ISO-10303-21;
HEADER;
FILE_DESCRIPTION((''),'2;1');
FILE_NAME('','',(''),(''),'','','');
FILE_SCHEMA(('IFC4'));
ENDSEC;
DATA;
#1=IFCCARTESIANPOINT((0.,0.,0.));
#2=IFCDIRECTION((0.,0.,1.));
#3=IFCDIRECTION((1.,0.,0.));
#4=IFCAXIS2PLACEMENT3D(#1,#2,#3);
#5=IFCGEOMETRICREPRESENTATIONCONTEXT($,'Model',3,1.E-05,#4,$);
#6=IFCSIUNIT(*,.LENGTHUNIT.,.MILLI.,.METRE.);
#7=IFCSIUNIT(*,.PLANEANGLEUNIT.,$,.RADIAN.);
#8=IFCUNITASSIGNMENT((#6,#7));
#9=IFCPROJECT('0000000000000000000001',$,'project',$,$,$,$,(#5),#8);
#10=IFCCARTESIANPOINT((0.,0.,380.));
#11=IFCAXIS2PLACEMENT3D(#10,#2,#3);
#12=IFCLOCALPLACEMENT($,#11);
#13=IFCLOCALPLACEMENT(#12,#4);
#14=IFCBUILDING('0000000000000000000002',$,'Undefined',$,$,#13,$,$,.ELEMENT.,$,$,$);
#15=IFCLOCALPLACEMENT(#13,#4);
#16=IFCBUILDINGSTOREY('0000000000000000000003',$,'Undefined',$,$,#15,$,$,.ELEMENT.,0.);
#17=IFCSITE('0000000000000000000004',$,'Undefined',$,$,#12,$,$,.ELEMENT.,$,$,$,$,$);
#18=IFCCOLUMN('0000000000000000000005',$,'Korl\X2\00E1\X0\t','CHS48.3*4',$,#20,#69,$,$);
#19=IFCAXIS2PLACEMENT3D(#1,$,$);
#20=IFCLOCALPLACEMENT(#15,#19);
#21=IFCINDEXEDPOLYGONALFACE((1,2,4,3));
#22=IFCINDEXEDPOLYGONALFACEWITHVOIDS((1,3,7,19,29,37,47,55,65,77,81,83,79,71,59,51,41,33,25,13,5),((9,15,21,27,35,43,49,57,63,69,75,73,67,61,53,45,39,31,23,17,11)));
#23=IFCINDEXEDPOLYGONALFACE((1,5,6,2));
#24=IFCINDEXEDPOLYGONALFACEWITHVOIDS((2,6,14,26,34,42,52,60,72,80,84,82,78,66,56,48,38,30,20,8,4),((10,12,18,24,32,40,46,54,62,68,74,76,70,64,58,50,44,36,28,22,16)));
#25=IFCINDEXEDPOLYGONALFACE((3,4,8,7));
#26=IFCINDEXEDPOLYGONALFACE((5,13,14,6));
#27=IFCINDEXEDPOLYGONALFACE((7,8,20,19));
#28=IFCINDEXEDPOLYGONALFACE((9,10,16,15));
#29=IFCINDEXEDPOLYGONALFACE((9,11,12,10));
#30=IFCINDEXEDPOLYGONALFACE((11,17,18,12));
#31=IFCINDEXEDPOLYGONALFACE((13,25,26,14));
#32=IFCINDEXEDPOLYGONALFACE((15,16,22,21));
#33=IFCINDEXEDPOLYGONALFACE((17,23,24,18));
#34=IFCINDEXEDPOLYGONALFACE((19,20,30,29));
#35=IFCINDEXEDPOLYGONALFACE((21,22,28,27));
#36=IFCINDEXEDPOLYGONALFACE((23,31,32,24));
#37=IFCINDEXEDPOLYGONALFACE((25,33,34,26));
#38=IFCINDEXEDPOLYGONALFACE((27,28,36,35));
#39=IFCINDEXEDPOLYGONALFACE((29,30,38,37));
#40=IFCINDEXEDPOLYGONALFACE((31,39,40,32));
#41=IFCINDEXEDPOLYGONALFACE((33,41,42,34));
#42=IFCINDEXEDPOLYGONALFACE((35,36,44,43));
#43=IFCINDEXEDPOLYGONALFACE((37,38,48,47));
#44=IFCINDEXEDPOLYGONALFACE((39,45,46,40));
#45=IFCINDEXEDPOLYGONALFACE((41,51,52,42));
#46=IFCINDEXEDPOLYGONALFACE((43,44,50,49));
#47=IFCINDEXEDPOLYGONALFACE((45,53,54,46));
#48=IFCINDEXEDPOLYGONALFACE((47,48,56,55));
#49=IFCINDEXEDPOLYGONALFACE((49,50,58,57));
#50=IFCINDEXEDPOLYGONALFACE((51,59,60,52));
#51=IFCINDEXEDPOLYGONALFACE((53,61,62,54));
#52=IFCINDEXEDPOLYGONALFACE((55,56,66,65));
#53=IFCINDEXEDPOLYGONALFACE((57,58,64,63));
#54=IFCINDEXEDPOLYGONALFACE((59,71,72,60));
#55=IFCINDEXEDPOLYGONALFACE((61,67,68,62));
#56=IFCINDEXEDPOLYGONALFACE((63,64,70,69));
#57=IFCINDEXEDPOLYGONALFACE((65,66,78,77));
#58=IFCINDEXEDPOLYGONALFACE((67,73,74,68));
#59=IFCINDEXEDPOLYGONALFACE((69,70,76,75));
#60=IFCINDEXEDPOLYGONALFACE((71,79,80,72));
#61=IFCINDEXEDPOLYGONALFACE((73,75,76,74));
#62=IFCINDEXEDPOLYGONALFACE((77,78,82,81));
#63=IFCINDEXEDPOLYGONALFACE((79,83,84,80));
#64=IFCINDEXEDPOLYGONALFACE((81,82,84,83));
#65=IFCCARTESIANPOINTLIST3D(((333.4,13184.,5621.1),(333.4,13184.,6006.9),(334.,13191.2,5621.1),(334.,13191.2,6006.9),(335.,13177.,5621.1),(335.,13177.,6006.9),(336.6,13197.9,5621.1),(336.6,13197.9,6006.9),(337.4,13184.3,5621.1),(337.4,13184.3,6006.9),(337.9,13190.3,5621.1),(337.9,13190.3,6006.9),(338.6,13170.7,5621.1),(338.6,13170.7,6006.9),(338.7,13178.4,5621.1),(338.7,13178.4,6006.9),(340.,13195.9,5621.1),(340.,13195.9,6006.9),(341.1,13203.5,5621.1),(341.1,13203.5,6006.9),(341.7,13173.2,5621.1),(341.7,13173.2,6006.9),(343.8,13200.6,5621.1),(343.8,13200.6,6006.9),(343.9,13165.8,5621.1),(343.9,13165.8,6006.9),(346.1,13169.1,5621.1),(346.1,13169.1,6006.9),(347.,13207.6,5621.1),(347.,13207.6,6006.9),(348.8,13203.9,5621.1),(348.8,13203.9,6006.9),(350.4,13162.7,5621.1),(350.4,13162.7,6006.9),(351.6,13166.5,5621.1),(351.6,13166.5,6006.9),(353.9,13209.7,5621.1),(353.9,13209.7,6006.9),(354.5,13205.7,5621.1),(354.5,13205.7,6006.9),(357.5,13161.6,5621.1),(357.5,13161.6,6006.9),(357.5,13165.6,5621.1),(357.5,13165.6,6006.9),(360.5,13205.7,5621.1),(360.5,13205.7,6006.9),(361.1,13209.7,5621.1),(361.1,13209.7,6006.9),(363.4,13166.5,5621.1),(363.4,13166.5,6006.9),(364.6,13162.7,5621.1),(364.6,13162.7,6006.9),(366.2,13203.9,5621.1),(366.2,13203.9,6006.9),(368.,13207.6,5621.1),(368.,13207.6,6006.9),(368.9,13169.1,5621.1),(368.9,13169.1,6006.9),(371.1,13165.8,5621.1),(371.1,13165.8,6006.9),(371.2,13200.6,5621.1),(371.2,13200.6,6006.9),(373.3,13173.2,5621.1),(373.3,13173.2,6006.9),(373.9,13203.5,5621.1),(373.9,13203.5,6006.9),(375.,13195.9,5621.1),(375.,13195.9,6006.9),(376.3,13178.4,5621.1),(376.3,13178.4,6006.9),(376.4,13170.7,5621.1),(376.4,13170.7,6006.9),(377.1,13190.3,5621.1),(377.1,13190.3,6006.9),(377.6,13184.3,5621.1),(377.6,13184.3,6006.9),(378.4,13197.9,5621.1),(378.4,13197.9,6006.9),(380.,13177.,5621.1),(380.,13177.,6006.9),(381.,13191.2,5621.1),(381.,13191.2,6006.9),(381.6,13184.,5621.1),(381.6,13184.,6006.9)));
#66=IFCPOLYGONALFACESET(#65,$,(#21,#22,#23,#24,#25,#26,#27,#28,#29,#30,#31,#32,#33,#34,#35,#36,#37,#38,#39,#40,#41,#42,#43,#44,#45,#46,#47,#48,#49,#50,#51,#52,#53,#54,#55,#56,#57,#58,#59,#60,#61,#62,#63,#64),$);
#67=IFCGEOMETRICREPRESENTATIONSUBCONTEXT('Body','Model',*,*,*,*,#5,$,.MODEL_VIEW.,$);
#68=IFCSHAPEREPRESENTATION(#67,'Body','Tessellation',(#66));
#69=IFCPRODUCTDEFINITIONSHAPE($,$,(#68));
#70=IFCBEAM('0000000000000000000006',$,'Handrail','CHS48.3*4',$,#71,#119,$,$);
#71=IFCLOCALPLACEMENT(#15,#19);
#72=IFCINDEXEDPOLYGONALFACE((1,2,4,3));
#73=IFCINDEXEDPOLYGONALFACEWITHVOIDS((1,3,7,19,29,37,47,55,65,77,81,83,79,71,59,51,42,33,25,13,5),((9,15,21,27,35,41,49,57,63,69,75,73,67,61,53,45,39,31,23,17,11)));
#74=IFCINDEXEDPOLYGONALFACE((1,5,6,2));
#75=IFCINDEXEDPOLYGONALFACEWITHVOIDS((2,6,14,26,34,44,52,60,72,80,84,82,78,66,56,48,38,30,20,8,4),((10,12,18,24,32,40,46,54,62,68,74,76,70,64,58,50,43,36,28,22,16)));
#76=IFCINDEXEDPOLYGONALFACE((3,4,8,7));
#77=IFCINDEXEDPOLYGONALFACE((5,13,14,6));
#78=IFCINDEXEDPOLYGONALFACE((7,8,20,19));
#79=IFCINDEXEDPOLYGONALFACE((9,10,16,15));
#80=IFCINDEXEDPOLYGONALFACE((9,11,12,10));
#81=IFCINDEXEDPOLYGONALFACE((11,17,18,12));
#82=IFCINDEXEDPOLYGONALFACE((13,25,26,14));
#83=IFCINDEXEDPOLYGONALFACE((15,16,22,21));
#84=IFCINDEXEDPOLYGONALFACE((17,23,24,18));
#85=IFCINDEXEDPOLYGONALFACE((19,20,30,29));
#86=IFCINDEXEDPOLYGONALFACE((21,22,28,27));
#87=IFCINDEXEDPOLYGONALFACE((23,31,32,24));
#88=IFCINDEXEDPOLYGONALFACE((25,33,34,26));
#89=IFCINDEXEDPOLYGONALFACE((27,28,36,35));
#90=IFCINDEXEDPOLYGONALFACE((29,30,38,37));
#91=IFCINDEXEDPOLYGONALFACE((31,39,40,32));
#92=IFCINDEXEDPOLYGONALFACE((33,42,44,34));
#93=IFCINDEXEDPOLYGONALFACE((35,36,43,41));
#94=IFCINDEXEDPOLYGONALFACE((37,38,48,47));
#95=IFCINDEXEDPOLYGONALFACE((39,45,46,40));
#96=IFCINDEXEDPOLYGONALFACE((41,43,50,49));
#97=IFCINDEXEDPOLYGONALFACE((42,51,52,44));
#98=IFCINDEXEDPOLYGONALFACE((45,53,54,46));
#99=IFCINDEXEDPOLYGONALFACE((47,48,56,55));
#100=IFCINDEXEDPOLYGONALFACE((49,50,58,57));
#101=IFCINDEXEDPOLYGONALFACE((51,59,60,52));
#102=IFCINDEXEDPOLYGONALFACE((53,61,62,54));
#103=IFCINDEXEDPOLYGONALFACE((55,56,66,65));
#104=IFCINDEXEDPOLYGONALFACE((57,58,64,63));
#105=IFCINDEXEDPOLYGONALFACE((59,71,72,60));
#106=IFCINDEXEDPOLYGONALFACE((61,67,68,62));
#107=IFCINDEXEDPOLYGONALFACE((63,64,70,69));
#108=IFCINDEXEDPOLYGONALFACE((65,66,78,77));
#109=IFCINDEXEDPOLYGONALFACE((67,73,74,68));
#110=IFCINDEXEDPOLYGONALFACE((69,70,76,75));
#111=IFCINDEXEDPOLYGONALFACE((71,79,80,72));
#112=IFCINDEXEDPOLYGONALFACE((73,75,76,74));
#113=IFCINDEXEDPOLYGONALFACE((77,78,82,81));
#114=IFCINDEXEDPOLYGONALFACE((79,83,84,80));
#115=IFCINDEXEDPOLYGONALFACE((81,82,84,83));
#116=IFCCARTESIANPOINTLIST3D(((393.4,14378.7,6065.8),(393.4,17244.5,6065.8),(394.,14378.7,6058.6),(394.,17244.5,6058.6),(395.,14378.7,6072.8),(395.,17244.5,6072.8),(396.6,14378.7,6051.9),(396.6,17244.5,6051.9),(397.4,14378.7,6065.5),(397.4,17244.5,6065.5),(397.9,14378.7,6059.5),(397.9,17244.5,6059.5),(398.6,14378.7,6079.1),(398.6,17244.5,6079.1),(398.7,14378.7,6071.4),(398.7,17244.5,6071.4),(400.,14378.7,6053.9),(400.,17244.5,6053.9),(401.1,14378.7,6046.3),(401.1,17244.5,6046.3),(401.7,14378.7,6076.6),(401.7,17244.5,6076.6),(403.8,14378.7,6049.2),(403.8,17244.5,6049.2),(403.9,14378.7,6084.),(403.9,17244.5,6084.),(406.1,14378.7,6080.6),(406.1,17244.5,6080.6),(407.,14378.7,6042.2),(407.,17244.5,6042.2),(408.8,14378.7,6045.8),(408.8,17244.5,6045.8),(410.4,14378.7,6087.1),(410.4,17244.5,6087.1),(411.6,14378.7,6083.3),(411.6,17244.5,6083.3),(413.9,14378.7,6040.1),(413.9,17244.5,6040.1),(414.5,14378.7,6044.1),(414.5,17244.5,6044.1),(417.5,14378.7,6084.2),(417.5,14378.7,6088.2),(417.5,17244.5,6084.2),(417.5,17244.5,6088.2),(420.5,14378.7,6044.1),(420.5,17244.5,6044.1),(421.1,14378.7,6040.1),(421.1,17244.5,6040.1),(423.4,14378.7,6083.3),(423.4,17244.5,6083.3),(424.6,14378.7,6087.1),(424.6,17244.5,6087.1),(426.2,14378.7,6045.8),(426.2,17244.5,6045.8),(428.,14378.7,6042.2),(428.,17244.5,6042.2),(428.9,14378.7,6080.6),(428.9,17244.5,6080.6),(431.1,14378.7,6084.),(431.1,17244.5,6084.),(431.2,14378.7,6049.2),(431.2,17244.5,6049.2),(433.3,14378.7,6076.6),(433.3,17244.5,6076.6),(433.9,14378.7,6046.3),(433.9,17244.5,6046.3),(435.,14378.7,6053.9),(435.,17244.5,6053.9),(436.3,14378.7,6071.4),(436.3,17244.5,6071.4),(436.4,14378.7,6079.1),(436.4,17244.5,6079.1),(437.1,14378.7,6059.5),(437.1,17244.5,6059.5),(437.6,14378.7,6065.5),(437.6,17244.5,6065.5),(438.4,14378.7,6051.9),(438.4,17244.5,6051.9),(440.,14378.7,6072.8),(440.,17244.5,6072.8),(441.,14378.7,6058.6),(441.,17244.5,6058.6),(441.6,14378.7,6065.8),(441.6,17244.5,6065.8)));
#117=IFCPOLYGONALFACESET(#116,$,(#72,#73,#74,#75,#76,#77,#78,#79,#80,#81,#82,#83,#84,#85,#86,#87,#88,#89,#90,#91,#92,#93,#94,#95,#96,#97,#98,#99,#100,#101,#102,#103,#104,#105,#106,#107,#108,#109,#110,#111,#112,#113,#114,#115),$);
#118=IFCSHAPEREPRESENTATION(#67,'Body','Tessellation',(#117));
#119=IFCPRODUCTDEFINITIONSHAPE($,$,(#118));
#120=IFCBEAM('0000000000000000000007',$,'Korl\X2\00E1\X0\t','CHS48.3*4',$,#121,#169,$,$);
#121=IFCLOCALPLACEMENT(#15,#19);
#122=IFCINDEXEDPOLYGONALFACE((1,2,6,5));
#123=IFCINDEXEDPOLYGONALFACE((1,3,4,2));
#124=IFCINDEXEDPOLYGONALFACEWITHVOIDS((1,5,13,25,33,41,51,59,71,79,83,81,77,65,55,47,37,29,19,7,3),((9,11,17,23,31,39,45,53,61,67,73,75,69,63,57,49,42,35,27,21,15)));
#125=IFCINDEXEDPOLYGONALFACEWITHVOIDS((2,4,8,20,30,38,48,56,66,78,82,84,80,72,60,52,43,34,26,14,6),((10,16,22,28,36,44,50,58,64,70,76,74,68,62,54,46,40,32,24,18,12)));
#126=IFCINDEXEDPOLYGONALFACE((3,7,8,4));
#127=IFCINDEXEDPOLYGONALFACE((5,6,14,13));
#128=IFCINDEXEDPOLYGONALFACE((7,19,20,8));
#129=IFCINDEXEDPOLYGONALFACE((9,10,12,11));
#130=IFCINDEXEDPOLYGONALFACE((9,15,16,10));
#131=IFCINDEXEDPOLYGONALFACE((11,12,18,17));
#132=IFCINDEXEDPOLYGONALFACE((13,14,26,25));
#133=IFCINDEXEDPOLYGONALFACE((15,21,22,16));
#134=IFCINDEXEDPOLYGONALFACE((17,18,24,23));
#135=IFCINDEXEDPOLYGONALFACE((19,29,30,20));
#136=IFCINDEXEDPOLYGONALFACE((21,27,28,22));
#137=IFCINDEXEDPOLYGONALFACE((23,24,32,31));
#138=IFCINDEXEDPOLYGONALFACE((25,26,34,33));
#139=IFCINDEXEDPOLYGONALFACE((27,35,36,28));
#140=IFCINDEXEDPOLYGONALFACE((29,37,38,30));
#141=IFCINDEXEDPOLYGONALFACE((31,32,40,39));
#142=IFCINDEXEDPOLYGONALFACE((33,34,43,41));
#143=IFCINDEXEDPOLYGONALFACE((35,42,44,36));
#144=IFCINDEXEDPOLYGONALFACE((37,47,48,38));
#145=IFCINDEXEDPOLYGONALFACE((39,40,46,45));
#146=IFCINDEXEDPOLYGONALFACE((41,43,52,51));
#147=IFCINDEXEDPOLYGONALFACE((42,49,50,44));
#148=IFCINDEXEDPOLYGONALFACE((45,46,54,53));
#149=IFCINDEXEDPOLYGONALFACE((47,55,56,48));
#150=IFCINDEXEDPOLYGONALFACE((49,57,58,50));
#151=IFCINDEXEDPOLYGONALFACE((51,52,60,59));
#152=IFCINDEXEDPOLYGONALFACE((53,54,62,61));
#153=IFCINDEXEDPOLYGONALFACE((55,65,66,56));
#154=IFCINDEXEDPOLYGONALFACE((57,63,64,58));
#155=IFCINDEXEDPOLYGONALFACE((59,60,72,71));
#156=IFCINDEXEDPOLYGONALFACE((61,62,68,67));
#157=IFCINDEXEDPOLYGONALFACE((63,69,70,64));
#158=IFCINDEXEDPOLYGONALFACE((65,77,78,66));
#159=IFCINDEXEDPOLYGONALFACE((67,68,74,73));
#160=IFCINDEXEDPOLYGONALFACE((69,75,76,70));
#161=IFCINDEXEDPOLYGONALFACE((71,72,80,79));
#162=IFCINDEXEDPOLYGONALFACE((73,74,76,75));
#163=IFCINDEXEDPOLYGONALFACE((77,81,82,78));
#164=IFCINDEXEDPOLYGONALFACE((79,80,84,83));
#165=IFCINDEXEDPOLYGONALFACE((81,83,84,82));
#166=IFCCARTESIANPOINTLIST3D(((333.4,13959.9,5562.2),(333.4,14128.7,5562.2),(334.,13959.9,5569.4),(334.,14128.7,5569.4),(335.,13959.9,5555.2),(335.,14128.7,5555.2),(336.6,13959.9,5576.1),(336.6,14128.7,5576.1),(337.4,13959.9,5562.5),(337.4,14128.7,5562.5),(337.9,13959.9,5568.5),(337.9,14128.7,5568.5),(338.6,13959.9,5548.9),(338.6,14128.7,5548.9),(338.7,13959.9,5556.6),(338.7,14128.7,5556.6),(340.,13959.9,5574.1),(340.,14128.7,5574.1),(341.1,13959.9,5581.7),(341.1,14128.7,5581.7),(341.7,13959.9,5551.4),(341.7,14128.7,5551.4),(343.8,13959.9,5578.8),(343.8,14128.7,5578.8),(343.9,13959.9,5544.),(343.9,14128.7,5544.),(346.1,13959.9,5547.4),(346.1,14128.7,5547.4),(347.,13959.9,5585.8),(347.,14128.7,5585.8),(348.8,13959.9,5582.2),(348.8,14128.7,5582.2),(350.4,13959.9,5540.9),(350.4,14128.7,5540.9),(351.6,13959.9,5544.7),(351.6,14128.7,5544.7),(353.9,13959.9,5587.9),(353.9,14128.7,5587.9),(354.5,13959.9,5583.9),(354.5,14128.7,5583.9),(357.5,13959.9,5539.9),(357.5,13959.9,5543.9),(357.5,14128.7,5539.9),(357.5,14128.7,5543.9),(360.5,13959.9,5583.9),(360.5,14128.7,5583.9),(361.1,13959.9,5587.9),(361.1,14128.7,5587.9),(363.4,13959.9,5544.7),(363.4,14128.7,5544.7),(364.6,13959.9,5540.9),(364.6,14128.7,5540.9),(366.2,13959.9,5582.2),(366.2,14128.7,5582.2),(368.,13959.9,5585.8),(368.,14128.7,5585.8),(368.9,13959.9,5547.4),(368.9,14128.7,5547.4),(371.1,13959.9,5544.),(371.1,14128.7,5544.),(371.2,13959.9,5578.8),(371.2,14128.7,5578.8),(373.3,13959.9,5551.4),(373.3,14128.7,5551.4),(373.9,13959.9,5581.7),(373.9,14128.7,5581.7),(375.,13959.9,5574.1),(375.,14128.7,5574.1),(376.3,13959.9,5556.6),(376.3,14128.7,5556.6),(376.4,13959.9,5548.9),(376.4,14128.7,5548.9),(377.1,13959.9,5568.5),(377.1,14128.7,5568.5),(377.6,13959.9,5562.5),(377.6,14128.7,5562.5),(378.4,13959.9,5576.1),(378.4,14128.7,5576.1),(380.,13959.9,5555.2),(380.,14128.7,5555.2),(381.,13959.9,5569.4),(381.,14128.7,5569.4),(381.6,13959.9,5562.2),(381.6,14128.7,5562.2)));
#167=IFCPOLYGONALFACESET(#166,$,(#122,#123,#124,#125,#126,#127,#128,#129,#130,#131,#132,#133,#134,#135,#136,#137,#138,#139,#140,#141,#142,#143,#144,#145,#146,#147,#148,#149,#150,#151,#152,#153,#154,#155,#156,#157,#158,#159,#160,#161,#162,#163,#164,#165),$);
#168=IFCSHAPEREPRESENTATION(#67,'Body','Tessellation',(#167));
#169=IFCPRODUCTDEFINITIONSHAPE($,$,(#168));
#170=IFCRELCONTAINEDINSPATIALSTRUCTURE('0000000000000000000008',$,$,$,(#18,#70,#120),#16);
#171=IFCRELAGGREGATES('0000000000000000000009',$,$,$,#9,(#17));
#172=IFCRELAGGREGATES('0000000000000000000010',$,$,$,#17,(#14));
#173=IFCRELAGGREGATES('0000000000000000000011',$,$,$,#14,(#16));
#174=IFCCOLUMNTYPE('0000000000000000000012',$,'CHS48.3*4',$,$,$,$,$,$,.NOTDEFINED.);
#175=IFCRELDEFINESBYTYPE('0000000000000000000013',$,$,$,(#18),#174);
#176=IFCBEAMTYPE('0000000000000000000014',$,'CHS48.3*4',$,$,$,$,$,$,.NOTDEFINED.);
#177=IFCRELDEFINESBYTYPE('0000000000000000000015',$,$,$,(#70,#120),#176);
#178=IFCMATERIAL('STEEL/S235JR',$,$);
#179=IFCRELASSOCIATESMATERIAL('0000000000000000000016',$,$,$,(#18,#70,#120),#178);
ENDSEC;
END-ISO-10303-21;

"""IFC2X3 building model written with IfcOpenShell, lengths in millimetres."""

from ifc_helpers import new_model, si_unit, frame, origin_with_axes, origin_2d_with_axis, place, context, subcontext, project, spatial, hollow_circle, extrude, material, type_object, element, save


model = new_model("IFC2X3")

# Units and contexts
model_context = context("Model", 3, precision=1e-05, world=origin_with_axes())
body_context = subcontext(model_context, "Body", "Model", "MODEL_VIEW")
ifc_project = project(units=[si_unit("LENGTHUNIT", "METRE", prefix="MILLI"), si_unit("PLANEANGLEUNIT", "RADIAN")], contexts=[model_context])

# Site, building, storey
site_placement = place(None, frame((0.0, 0.0, 380.0), z_axis=(0.0, 0.0, 1.0), x_axis=(1.0, 0.0, 0.0)))
site = spatial("IfcSite", under=ifc_project, at=site_placement, Name="Undefined", CompositionType="ELEMENT")
building_placement = place(site_placement, origin_with_axes())
building = spatial("IfcBuilding", under=site, at=building_placement, Name="Undefined", CompositionType="ELEMENT")
storey_placement = place(building_placement, origin_with_axes())
storey = spatial("IfcBuildingStorey", under=building, at=storey_placement, Name="Undefined", CompositionType="ELEMENT", Elevation=0.0)

# Column
ifc_material_1 = material(Name="STEEL/S235JR")
column_type = type_object("IfcColumnType", Name="CHS48.3*4", PredefinedType="NOTDEFINED")
column_1_placement = place(storey_placement, frame((357.5, 13185.8, 5621.1), z_axis=(0.0, 0.0, 1.0), x_axis=(-1.0, 0.0, 0.0)))
element("IfcColumn", 1, at=column_1_placement, inside=storey, type_object=column_type, material=ifc_material_1, Name="Korlát", Description="CHS48.3*4", context=body_context, shape_type="SweptSolid", body=[
    extrude(hollow_circle(Radius=24.1, WallThickness=4.0, at=origin_2d_with_axis()), frame((0.0, 0.0, 385.8), z_axis=(0.0, 0.0, -1.0), x_axis=(0.0, 1.0, 0.0)), (0.0, 0.0, 1.0), 385.8),
])

# Beams
beam_type_1 = type_object("IfcBeamType", Name="CHS48.3*4", PredefinedType="NOTDEFINED")
beam_1_placement = place(storey_placement, frame((417.5, 14378.7, 6064.0), z_axis=(-1.0, 0.0, 0.0), x_axis=(0.0, 1.0, 0.0)))
element("IfcBeam", 2, at=beam_1_placement, inside=storey, type_object=beam_type_1, material=ifc_material_1, Name="Handrail", Description="CHS48.3*4", context=body_context, shape_type="SweptSolid", body=[
    extrude(hollow_circle(Radius=24.1, WallThickness=4.0, at=origin_2d_with_axis()), frame((2865.8, 0.0, 0.0), z_axis=(-1.0, 0.0, 0.0), x_axis=(0.0, -1.0, 0.0)), (0.0, 0.0, 1.0), 2865.8),
])
beam_2_placement = place(storey_placement, frame((357.5, 14128.7, 5564.0), z_axis=(-1.0, 0.0, 0.0), x_axis=(0.0, -1.0, 0.0)))
element("IfcBeam", 3, at=beam_2_placement, inside=storey, type_object=beam_type_1, material=ifc_material_1, Name="Korlát", Description="CHS48.3*4", context=body_context, shape_type="SweptSolid", body=[
    extrude(hollow_circle(Radius=24.1, WallThickness=4.0, at=origin_2d_with_axis()), frame((168.8, 0.0, 0.0), z_axis=(-1.0, 0.0, 0.0), x_axis=(0.0, -1.0, 0.0)), (0.0, 0.0, 1.0), 168.8),
])

save(model, "model.ifc")
